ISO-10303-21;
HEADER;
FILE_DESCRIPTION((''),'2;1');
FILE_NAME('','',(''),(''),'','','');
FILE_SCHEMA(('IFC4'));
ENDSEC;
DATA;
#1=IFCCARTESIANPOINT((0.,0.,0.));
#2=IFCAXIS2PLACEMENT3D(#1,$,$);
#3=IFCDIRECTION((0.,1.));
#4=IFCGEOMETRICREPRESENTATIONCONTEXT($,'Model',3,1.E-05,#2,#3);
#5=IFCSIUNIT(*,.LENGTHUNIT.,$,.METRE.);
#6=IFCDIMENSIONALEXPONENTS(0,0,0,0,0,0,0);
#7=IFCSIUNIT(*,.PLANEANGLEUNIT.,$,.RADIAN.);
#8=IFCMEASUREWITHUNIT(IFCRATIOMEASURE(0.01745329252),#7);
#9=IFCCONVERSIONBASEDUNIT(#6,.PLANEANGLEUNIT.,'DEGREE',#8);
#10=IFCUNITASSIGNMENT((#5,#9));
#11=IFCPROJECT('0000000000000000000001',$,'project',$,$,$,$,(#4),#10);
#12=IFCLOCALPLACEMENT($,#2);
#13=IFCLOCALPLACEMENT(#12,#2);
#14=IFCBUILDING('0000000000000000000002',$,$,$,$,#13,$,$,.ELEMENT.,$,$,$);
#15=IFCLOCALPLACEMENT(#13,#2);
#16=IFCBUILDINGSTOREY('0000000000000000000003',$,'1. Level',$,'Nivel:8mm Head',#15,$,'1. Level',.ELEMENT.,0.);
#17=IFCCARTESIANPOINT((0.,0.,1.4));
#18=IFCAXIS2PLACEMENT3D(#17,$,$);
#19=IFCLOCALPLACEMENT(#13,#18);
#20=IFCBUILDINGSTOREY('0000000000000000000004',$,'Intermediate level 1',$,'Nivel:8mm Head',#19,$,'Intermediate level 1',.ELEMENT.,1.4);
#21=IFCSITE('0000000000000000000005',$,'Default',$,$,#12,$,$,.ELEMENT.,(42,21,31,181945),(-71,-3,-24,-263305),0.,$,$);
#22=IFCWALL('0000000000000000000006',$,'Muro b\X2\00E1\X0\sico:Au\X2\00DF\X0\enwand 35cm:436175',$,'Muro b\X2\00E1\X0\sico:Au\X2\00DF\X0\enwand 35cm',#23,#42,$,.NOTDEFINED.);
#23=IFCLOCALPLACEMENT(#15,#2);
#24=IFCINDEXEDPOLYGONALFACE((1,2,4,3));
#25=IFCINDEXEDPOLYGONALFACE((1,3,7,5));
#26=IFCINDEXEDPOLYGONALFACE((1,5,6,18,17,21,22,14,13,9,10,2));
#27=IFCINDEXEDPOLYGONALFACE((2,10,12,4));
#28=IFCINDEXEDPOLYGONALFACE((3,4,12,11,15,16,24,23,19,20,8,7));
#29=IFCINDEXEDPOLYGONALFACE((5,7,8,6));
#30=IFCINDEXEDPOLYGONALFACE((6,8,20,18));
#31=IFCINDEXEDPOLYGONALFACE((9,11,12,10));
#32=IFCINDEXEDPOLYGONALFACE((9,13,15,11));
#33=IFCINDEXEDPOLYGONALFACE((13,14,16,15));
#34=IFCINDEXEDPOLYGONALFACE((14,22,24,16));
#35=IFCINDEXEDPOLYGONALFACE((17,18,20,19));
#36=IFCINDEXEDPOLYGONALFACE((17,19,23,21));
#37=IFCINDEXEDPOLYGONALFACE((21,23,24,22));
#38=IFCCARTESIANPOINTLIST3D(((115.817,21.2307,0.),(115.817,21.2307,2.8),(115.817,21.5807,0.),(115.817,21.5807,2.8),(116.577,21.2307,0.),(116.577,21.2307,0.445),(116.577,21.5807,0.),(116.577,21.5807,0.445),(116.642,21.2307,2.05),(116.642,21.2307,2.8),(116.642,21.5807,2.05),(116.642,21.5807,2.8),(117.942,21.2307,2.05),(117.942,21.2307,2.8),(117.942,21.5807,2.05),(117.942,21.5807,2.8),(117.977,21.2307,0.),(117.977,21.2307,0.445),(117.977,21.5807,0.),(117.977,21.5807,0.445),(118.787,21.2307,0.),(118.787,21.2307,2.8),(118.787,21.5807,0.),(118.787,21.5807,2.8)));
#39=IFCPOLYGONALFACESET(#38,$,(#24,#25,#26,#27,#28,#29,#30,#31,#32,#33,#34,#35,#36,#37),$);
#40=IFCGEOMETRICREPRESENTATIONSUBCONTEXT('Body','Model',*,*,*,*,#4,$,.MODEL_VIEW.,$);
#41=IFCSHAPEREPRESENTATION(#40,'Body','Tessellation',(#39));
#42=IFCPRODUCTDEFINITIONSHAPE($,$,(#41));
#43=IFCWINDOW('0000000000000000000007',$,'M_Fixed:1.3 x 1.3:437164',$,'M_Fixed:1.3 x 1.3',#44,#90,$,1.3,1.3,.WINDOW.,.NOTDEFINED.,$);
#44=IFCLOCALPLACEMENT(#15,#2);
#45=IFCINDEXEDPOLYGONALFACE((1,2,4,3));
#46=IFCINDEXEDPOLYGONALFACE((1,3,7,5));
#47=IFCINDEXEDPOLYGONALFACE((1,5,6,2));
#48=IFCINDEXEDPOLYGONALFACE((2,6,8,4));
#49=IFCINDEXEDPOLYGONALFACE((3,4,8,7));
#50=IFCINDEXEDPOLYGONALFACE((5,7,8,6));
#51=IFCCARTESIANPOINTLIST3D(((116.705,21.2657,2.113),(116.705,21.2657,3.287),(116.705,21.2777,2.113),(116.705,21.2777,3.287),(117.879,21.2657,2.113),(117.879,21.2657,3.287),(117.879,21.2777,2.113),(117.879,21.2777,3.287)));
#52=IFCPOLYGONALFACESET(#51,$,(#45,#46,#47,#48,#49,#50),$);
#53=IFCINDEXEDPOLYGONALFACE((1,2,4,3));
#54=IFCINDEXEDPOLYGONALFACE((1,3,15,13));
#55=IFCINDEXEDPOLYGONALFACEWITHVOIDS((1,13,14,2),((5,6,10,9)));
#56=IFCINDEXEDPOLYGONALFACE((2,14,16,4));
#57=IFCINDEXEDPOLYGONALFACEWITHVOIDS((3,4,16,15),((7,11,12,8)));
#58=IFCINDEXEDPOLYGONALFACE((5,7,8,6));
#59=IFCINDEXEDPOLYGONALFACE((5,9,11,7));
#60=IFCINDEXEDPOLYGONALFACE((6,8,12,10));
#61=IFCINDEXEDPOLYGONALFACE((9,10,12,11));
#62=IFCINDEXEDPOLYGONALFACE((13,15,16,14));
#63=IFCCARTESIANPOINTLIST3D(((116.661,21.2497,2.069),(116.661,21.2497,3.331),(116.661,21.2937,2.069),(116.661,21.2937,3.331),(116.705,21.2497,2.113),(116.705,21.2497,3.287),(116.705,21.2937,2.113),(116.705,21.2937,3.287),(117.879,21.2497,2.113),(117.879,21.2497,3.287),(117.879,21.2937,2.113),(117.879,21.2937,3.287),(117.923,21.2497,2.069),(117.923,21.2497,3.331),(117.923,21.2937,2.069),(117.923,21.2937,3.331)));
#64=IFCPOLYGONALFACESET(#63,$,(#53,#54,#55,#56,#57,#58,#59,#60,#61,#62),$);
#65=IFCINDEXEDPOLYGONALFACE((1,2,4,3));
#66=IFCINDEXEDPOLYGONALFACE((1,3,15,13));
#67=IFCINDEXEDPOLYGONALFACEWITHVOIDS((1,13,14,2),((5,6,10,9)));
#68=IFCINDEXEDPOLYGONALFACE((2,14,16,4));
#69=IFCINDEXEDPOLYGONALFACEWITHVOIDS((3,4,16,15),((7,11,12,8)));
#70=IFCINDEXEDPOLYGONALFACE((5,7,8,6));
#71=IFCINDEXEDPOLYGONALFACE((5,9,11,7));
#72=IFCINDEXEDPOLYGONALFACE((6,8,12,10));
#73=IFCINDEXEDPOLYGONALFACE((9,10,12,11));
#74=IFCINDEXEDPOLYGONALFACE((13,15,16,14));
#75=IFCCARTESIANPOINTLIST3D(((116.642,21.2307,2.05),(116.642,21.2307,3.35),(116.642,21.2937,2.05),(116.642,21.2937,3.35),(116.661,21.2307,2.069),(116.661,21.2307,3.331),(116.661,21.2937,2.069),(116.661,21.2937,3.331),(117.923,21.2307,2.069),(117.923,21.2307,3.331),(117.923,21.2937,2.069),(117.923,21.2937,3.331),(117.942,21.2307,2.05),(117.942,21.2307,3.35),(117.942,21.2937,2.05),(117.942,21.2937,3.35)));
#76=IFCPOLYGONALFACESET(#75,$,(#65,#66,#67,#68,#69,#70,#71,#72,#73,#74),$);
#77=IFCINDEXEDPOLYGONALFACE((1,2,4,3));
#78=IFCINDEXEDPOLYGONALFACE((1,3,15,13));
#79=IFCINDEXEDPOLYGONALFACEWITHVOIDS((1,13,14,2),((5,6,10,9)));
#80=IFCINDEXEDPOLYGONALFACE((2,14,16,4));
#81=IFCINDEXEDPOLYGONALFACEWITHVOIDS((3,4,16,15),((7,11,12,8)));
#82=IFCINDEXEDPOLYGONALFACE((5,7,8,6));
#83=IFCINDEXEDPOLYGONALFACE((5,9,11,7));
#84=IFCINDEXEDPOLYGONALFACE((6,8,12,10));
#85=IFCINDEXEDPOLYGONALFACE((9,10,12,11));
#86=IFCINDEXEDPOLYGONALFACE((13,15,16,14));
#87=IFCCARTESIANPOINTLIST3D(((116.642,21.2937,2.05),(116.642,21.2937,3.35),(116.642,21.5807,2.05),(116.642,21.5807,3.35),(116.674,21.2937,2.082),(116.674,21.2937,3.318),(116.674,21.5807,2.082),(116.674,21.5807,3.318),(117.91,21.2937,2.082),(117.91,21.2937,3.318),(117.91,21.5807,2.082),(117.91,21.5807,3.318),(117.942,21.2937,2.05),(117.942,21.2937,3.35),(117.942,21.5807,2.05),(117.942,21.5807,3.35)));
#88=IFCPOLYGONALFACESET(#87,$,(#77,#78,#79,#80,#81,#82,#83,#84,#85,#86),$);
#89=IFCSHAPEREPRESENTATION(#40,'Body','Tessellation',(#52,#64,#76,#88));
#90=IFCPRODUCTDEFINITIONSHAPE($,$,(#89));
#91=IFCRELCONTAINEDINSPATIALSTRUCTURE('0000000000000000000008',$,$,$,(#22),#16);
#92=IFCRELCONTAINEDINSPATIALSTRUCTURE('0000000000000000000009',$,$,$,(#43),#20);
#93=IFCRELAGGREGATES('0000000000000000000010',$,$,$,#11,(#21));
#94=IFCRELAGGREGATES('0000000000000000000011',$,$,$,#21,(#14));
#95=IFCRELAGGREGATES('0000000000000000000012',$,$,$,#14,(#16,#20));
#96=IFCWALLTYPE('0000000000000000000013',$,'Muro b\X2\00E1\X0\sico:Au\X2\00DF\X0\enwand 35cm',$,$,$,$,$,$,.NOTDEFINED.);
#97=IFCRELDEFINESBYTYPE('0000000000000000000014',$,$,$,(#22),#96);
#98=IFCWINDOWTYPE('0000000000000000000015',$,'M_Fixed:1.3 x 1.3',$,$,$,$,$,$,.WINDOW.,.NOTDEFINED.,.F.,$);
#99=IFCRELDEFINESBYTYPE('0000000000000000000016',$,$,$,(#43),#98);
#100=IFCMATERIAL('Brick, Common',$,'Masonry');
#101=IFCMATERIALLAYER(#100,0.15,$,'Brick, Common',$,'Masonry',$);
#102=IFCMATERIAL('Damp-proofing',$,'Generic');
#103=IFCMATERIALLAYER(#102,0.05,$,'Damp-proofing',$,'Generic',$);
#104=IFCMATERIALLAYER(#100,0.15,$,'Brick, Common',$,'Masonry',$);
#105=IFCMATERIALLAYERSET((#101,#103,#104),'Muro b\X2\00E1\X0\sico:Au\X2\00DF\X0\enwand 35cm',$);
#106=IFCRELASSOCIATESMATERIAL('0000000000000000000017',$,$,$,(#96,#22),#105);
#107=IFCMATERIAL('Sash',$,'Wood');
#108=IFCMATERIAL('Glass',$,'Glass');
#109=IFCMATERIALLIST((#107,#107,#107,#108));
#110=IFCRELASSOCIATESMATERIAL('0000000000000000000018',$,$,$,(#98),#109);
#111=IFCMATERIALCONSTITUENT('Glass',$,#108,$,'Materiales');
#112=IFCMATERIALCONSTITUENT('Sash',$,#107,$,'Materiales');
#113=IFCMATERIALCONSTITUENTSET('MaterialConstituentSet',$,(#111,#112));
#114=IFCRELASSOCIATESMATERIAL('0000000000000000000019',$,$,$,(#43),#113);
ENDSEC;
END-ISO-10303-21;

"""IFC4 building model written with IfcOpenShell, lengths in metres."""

from ifc_helpers import new_model, entity, si_unit, converted_unit, direction, frame, frame_2d, origin, origin_2d_with_axis, place, context, subcontext, project, spatial, polyline, rectangle, outline, extrude, source, transform, mapped, material, material_list, layer, layer_set, layer_usage, constituent, constituent_set, type_object, type_shapes, element, fill, save


model = new_model("IFC4")

# Units and contexts
model_context = context("Model", 3, precision=1e-05, world=origin(), true_north=direction((0.0, 1.0)))
body_context = subcontext(model_context, "Body", "Model", "MODEL_VIEW")
ifc_project = project(units=[si_unit("LENGTHUNIT", "METRE"), converted_unit("PLANEANGLEUNIT", "DEGREE", entity("IfcRatioMeasure", 0.01745329252), si_unit("PLANEANGLEUNIT", "RADIAN"), dimensions=[0, 0, 0, 0, 0, 0, 0])], contexts=[model_context])

# Site, building, storey
site_placement = place(None, origin())
site = spatial("IfcSite", under=ifc_project, at=site_placement, Name="Default", CompositionType="ELEMENT", RefLatitude=(42, 21, 31, 181945), RefLongitude=(-71, -3, -24, -263305), RefElevation=0.0)
building_placement = place(site_placement, origin())
building = spatial("IfcBuilding", under=site, at=building_placement, CompositionType="ELEMENT")
storey_1_placement = place(building_placement, origin())
storey_1 = spatial("IfcBuildingStorey", under=building, at=storey_1_placement, Name="1. Level", ObjectType="Nivel:8mm Head", LongName="1. Level", CompositionType="ELEMENT", Elevation=0.0)

# Wall, openings
ifc_material_1 = material(Name="Brick, Common", Category="Masonry")
ifc_layer_1 = layer(ifc_material_1, 0.15, Name="Brick, Common", Category="Masonry")
ifc_material_2 = material(Name="Damp-proofing", Category="Generic")
ifc_layer_2 = layer(ifc_material_2, 0.05, Name="Damp-proofing", Category="Generic")
ifc_layer_3 = layer(ifc_material_1, 0.15, Name="Brick, Common", Category="Masonry")
ifc_layer_set_1 = layer_set([ifc_layer_1, ifc_layer_2, ifc_layer_3], Name="Muro básico:Außenwand 35cm")
ifc_layer_usage_1 = layer_usage(ifc_layer_set_1, "AXIS2", "NEGATIVE", 0.175)
wall_type_1 = type_object("IfcWallType", Name="Muro básico:Außenwand 35cm", PredefinedType="NOTDEFINED", material=ifc_layer_set_1)
wall_1_placement = place(storey_1_placement, frame((115.817, 21.4057, 0.0)))
wall_1 = element("IfcWall", 1, at=wall_1_placement, inside=storey_1, type_object=wall_type_1, material=ifc_layer_usage_1, Name="Muro básico:Außenwand 35cm:436175", ObjectType="Muro básico:Außenwand 35cm", PredefinedType="NOTDEFINED", context=body_context, shape_type="SweptSolid", body=[
    extrude(rectangle(XDim=2.97, YDim=0.35, at=frame_2d((1.485, 0.0), x_axis=(-1.0, 0.0))), origin(), (0.0, 0.0, 1.0), 2.8),
])
opening_1_placement = place(wall_1_placement, origin())
element("IfcOpeningElement", 2, at=opening_1_placement, cuts=wall_1, ObjectType="Opening", PredefinedType="OPENING", context=body_context, shape_type="SweptSolid", body=[
    extrude(rectangle(XDim=2.225, YDim=1.4, at=frame_2d((0.0, 0.0), x_axis=(0.0, 1.0))), frame((1.46, -1.349, -0.6675), z_axis=(0.0, 1.0, 0.0), x_axis=(1.0, 0.0, 0.0)), (0.0, 0.0, 1.0), 3.048),
])
opening_2_placement = place(wall_1_placement, frame((-115.817, -21.4057, 1.4)))
element("IfcOpeningElement", 3, at=opening_2_placement, cuts=wall_1, ObjectType="Opening", PredefinedType="OPENING", context=body_context, shape_type="SweptSolid", body=[
    extrude(rectangle(XDim=1.3, YDim=1.3, at=frame_2d((0.0, 0.0), x_axis=(0.0, 1.0))), frame((117.292, 20.0567, 1.3), z_axis=(0.0, 1.0, 0.0), x_axis=(-1.0, 0.0, 0.0)), (0.0, 0.0, 1.0), 3.048),
])
opening_3_placement = place(wall_1_placement, frame((2.125, 0.175, 2.05)))
opening_3 = element("IfcOpeningElement", 4, at=opening_3_placement, cuts=wall_1, ObjectType="Opening", PredefinedType="OPENING", context=body_context, shape_type="SweptSolid", body=[
    extrude(rectangle(XDim=1.3, YDim=1.3, at=frame_2d((0.65, 0.65), x_axis=(1.0, 0.0))), frame((0.0, 0.0, 0.0), z_axis=(0.0, -1.0, 0.0), x_axis=(0.0, 0.0, 1.0)), (0.0, 0.0, 1.0), 0.35),
])

# Shared definitions
storey_2_placement = place(building_placement, frame((0.0, 0.0, 1.4)))
storey_2 = spatial("IfcBuildingStorey", under=building, at=storey_2_placement, Name="Intermediate level 1", ObjectType="Nivel:8mm Head", LongName="Intermediate level 1", CompositionType="ELEMENT", Elevation=1.4)

# Window
ifc_material_3 = material(Name="Glass", Category="Glass")
ifc_constituent_1 = constituent(ifc_material_3, Name="Glass", Category="Materiales")
ifc_material_4 = material(Name="Sash", Category="Wood")
ifc_constituent_2 = constituent(ifc_material_4, Name="Sash", Category="Materiales")
ifc_constituent_set_1 = constituent_set(constituents=[ifc_constituent_1, ifc_constituent_2], Name="MaterialConstituentSet")
ifc_material_list_1 = material_list([ifc_material_4, ifc_material_4, ifc_material_4, ifc_material_3])
window_type = type_object("IfcWindowType", Name="M_Fixed:1.3 x 1.3", ParameterTakesPrecedence=False, PartitioningType="NOTDEFINED", PredefinedType="WINDOW", material=ifc_material_list_1)
shared_shape_1 = source(origin(), body_context, "Body", "SweptSolid", [
    extrude(rectangle(XDim=0.012, YDim=1.174, at=origin_2d_with_axis()), frame((0.65, 0.309, 0.063), z_axis=(0.0, 0.0, 1.0), x_axis=(0.0, -1.0, 0.0)), (0.0, 0.0, 1.0), 1.174),
    extrude(outline(polyline([(-0.631, -0.631), (0.631, -0.631), (0.631, 0.631), (-0.631, 0.631), (-0.631, -0.631)]), holes=[polyline([(-0.587, -0.587), (-0.587, 0.587), (0.587, 0.587), (0.587, -0.587), (-0.587, -0.587)])]), frame((0.65, 0.287, 0.65), z_axis=(0.0, 1.0, 0.0), x_axis=(1.0, 0.0, 0.0)), (0.0, 0.0, 1.0), 0.044),
    extrude(outline(polyline([(-0.65, -0.65), (0.65, -0.65), (0.65, 0.65), (-0.65, 0.65), (-0.65, -0.65)]), holes=[polyline([(-0.631, -0.631), (-0.631, 0.631), (0.631, 0.631), (0.631, -0.631), (-0.631, -0.631)])]), frame((0.65, 0.287, 0.65), z_axis=(0.0, 1.0, 0.0), x_axis=(1.0, 0.0, 0.0)), (0.0, 0.0, 1.0), 0.063),
    extrude(outline(polyline([(-0.65, -0.65), (0.65, -0.65), (0.65, 0.65), (-0.65, 0.65), (-0.65, -0.65)]), holes=[polyline([(-0.618, -0.618), (-0.618, 0.618), (0.618, 0.618), (0.618, -0.618), (-0.618, -0.618)])]), frame((0.65, 0.0, 0.65), z_axis=(0.0, 1.0, 0.0), x_axis=(1.0, 0.0, 0.0)), (0.0, 0.0, 1.0), 0.287),
])
type_shapes(window_type, [shared_shape_1])
window_placement = place(opening_3_placement, frame((0.0, 0.0, 0.0), z_axis=(0.0, 0.0, 1.0), x_axis=(-1.0, 0.0, 0.0)))
window = element("IfcWindow", 5, at=window_placement, inside=storey_2, type_object=window_type, material=ifc_constituent_set_1, Name="M_Fixed:1.3 x 1.3:437164", ObjectType="M_Fixed:1.3 x 1.3", OverallHeight=1.3, OverallWidth=1.3, PartitioningType="NOTDEFINED", PredefinedType="WINDOW", context=body_context, shape_type="MappedRepresentation", body=[
    mapped(shared_shape_1, transform((0.0, 0.0, 0.0), scale=1.0)),
])
fill(opening_3, window)

save(model, "model.ifc")
